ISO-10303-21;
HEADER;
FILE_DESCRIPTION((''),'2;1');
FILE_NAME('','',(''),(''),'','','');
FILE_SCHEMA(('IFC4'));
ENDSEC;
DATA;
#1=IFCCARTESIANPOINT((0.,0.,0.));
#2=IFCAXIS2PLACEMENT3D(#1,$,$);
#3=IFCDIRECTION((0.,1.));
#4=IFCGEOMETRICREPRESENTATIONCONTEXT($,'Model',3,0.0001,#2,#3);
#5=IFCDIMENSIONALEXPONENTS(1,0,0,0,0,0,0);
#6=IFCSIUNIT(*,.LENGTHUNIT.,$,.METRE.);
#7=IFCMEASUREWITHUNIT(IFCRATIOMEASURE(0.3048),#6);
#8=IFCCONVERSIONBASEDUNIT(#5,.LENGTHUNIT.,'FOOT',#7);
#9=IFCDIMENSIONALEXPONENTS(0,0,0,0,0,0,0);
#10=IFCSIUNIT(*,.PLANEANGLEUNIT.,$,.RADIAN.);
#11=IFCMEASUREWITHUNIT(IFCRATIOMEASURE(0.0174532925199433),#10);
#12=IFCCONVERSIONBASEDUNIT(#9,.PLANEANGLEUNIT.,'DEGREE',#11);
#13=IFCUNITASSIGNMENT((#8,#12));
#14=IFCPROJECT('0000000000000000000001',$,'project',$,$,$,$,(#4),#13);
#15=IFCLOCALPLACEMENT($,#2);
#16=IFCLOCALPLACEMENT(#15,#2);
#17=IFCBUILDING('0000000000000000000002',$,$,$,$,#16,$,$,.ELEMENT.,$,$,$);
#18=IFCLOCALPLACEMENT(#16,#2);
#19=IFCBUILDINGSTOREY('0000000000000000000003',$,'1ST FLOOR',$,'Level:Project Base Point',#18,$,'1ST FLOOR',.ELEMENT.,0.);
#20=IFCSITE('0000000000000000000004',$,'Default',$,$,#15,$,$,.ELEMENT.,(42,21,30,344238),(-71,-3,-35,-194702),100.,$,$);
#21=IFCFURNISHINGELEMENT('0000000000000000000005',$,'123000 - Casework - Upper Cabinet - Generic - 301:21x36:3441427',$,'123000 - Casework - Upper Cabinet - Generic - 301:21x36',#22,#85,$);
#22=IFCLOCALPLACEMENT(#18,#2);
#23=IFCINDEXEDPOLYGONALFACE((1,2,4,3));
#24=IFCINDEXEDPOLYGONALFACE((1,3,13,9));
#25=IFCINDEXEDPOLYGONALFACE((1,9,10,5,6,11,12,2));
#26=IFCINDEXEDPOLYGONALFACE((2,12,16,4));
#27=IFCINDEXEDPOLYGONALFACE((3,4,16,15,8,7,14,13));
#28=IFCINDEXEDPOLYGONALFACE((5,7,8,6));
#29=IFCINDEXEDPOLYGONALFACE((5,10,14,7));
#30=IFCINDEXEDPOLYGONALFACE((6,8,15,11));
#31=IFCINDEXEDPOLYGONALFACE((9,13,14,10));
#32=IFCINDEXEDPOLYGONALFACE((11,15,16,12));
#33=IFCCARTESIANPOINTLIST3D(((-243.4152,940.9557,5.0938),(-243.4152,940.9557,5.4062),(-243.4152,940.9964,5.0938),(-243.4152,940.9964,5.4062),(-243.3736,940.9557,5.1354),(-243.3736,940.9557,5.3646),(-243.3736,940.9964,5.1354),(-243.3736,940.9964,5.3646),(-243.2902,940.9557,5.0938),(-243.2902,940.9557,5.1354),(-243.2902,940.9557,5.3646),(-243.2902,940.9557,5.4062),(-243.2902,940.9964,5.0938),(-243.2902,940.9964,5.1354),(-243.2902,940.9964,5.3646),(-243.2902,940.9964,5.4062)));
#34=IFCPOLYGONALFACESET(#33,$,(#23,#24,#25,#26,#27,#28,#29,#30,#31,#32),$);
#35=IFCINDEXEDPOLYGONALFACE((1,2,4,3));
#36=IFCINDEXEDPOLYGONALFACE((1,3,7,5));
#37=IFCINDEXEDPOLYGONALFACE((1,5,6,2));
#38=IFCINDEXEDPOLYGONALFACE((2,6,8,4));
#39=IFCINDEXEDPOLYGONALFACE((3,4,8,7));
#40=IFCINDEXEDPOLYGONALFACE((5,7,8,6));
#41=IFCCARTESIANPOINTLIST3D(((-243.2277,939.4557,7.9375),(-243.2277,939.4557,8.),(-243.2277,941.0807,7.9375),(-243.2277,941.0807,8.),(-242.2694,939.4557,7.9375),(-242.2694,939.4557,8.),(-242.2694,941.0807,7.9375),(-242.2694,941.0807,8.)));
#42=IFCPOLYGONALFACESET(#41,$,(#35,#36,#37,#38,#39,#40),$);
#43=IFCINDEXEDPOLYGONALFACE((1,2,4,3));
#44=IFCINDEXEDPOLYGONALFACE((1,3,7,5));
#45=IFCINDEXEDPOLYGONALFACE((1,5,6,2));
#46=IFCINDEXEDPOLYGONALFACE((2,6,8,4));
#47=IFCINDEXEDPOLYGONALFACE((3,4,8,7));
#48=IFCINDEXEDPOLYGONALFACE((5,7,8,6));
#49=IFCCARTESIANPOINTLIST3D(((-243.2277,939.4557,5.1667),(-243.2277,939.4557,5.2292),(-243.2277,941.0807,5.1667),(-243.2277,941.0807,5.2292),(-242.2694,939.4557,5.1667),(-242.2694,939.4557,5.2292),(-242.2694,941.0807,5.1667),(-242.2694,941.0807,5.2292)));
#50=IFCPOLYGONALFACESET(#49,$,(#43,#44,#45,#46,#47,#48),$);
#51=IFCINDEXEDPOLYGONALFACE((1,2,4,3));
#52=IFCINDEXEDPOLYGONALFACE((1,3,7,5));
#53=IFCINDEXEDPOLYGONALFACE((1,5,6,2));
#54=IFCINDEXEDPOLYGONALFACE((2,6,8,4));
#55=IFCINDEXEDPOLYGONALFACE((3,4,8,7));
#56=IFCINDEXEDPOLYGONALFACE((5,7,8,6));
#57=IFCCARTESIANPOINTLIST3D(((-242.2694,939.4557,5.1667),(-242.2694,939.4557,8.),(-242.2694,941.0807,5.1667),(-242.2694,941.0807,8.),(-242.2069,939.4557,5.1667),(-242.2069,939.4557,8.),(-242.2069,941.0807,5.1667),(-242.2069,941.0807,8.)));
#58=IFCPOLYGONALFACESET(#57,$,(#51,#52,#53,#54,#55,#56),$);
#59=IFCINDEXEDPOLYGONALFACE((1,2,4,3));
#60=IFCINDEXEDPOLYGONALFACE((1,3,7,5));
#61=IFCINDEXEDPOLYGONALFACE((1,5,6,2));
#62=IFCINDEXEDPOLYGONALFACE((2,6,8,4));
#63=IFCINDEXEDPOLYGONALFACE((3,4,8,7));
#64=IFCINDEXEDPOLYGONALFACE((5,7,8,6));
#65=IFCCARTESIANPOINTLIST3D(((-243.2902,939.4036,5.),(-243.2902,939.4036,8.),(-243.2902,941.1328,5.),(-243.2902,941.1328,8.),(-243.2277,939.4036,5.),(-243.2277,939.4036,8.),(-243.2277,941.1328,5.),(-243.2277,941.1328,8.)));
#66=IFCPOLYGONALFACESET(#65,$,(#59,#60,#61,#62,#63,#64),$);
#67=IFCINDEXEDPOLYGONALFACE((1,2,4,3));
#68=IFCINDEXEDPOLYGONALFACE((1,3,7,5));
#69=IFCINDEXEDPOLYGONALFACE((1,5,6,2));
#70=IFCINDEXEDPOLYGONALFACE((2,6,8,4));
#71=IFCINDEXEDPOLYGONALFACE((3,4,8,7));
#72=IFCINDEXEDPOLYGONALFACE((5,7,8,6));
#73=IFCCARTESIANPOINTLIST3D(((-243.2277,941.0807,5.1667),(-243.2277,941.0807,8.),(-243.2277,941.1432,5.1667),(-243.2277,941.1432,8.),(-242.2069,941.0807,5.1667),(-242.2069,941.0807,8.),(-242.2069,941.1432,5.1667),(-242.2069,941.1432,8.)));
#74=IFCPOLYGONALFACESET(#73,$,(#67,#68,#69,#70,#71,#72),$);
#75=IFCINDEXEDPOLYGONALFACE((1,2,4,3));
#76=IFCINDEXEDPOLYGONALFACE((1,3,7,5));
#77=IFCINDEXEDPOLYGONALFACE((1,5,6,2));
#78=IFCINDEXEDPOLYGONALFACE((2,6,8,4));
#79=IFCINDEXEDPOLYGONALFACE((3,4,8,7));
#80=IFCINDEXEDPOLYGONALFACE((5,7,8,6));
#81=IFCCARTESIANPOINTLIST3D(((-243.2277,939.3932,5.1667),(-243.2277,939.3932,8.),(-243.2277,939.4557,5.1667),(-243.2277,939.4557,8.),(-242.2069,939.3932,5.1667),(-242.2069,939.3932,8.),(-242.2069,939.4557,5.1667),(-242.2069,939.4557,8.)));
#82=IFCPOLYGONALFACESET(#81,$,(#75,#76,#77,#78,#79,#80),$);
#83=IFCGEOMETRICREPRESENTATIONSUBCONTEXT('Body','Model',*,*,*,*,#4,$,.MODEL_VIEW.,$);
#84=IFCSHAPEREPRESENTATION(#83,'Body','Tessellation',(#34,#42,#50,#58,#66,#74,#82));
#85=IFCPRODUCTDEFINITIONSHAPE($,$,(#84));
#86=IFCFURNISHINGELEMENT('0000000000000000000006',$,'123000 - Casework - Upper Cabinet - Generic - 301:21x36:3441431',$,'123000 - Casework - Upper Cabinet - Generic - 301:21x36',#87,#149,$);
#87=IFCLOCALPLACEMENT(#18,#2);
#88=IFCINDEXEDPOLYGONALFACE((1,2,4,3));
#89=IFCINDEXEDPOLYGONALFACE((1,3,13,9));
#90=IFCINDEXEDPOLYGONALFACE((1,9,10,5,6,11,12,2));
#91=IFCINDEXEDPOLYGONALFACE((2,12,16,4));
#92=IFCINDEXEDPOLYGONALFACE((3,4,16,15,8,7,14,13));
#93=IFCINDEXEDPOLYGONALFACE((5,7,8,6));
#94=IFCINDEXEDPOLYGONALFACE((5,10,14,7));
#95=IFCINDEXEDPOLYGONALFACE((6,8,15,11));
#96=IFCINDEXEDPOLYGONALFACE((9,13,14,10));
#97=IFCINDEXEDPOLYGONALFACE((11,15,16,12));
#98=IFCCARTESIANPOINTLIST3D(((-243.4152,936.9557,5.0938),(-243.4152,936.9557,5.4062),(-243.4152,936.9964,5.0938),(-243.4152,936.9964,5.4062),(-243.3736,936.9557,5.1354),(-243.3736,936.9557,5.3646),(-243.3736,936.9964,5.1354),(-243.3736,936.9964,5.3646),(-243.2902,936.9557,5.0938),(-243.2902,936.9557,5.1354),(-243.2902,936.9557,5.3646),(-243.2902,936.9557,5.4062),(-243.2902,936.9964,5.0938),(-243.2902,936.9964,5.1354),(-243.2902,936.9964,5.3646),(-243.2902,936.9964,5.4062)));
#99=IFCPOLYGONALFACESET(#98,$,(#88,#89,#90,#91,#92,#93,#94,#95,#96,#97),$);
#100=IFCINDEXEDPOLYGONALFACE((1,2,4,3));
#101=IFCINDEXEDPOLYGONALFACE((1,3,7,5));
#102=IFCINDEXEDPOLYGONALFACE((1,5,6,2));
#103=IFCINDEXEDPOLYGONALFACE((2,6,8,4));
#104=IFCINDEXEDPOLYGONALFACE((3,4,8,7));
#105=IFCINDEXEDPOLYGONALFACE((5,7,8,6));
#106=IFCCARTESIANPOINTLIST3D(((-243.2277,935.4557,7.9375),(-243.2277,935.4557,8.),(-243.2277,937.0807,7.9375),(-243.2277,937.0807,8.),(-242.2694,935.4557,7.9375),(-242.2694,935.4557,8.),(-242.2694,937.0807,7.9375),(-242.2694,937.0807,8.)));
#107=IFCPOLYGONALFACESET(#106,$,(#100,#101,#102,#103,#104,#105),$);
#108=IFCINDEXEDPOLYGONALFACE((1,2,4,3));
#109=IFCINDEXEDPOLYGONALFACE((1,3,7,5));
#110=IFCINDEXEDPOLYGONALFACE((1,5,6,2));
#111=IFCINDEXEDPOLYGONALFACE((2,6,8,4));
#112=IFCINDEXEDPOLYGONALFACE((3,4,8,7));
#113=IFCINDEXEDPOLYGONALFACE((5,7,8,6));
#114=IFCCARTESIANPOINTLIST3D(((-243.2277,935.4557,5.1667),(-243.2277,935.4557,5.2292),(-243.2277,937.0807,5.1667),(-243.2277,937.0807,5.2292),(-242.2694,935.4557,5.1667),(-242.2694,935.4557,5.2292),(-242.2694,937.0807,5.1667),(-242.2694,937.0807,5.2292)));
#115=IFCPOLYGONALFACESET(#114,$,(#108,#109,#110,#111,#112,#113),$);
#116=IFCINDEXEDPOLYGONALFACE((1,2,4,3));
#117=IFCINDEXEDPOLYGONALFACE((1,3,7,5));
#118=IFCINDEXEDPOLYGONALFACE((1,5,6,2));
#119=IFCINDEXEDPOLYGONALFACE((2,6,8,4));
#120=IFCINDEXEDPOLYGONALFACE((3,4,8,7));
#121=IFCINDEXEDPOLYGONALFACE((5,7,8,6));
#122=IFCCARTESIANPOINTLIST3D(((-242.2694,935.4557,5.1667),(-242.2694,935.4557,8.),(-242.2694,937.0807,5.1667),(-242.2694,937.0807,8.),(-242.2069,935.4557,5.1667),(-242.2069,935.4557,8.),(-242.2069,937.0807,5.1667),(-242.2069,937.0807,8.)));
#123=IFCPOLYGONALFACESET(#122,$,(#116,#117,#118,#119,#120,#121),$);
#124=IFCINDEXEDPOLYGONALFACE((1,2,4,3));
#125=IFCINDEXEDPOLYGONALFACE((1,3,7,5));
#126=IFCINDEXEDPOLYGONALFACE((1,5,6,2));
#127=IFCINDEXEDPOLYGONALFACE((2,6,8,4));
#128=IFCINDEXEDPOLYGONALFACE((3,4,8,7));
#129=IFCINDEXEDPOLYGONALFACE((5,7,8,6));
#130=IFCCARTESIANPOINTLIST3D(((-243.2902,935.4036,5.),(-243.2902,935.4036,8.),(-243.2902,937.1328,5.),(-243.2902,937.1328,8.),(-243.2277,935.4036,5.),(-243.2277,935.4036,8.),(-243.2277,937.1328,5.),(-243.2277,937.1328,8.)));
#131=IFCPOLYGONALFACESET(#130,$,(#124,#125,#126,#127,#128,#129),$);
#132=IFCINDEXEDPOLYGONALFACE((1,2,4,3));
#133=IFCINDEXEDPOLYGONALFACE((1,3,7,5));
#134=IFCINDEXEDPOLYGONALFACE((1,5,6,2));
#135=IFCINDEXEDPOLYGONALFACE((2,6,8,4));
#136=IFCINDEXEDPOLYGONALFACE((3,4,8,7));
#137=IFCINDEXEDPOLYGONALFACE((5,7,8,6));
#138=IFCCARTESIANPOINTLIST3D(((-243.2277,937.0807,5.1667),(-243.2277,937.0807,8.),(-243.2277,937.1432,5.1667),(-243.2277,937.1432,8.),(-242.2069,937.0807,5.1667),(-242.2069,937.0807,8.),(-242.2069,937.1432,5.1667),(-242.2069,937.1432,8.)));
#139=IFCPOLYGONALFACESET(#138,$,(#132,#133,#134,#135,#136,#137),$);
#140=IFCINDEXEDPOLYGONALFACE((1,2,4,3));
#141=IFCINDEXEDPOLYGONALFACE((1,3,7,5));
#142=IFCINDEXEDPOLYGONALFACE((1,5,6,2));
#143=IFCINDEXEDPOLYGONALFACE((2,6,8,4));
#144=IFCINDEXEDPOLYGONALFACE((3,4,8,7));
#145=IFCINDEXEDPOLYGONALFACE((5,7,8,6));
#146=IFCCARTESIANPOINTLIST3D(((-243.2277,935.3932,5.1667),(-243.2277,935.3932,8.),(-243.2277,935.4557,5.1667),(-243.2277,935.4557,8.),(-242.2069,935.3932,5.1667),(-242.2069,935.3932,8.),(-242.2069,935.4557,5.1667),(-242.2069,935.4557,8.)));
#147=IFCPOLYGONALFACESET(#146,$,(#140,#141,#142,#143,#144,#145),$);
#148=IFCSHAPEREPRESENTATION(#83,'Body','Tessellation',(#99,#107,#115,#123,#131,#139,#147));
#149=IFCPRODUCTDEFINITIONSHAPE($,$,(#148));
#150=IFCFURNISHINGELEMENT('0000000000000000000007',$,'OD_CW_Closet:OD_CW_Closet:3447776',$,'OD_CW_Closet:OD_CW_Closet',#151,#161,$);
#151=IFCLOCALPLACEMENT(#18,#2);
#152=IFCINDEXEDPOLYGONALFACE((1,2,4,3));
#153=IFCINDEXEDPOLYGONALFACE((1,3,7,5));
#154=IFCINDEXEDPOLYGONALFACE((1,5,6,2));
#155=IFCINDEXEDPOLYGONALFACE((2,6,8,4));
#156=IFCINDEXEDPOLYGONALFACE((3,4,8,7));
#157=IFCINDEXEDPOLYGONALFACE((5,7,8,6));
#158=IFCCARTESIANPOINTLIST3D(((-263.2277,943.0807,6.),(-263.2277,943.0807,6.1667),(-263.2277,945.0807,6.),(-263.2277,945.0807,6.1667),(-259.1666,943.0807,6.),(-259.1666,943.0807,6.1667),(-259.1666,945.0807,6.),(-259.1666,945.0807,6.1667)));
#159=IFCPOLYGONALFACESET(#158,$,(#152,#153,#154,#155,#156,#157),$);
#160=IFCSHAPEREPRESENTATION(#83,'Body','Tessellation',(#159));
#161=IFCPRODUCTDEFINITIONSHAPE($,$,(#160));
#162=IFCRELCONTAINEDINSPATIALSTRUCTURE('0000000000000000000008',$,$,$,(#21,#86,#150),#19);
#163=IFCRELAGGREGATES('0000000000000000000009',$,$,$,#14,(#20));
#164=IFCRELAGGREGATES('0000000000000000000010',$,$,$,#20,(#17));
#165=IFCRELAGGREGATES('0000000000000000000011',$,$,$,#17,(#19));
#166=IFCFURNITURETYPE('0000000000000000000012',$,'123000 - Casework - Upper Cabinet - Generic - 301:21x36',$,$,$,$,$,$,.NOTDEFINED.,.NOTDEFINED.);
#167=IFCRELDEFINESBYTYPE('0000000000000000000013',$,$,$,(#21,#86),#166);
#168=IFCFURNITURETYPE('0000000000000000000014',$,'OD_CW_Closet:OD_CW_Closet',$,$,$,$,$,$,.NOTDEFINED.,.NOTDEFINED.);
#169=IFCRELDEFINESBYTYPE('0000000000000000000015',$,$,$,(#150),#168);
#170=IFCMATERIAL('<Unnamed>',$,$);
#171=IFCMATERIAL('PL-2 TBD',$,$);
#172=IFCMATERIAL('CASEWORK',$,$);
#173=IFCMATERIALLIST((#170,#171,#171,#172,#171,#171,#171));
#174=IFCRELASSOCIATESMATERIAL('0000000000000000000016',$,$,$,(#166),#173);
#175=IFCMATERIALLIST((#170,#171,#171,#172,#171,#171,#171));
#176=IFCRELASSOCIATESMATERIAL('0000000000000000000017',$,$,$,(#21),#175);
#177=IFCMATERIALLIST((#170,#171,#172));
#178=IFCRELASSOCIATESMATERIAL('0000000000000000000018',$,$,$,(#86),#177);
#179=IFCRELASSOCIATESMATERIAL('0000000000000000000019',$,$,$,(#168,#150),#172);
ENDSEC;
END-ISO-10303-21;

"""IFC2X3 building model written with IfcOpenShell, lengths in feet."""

from ifc_helpers import new_model, entity, si_unit, converted_unit, direction, frame, frame_2d, origin, origin_2d_with_axis, place, context, subcontext, project, spatial, polyline, rectangle, outline, extrude, source, transform, mapped, material, material_list, type_object, type_shapes, element, save


model = new_model("IFC2X3")

# Units and contexts
model_context = context("Model", 3, precision=0.0001, world=origin(), true_north=direction((0.0, 1.0)))
body_context = subcontext(model_context, "Body", "Model", "MODEL_VIEW")
ifc_project = project(units=[converted_unit("LENGTHUNIT", "FOOT", entity("IfcRatioMeasure", 0.3048), si_unit("LENGTHUNIT", "METRE"), dimensions=[1, 0, 0, 0, 0, 0, 0]), converted_unit("PLANEANGLEUNIT", "DEGREE", entity("IfcRatioMeasure", 0.0174532925199433), si_unit("PLANEANGLEUNIT", "RADIAN"), dimensions=[0, 0, 0, 0, 0, 0, 0])], contexts=[model_context])

# Site, building, storey
site_placement = place(None, origin())
site = spatial("IfcSite", under=ifc_project, at=site_placement, Name="Default", CompositionType="ELEMENT", RefLatitude=(42, 21, 30, 344238), RefLongitude=(-71, -3, -35, -194702), RefElevation=100.0)
building_placement = place(site_placement, origin())
building = spatial("IfcBuilding", under=site, at=building_placement, CompositionType="ELEMENT")
storey_placement = place(building_placement, origin())
storey = spatial("IfcBuildingStorey", under=building, at=storey_placement, Name="1ST FLOOR", ObjectType="Level:Project Base Point", LongName="1ST FLOOR", CompositionType="ELEMENT", Elevation=0.0)

# Furnishing elements
ifc_material_1 = material(Name="CASEWORK")
ifc_material_2 = material(Name="<Unnamed>")
ifc_material_3 = material(Name="PL-2 TBD")
ifc_material_list_1 = material_list([ifc_material_2, ifc_material_3, ifc_material_3, ifc_material_1, ifc_material_3, ifc_material_3, ifc_material_3])
ifc_material_list_2 = material_list([ifc_material_2, ifc_material_3, ifc_material_3, ifc_material_1, ifc_material_3, ifc_material_3, ifc_material_3])
furniture_type_1 = type_object("IfcFurnitureType", Name="123000 - Casework - Upper Cabinet - Generic - 301:21x36", material=ifc_material_list_2)
shared_shape_1 = source(origin(), body_context, "Body", "SweptSolid", [
    extrude(outline(polyline([(0.1146, -0.0521), (0.1562, -0.0521), (0.1562, 0.0729), (-0.1562, 0.0729), (-0.1562, -0.0521), (-0.1146, -0.0521), (-0.1146, 0.0313), (0.1146, 0.0313), (0.1146, -0.0521)])), frame((0.1468, 0.0729, 0.25), z_axis=(1.0, 0.0, 0.0), x_axis=(0.0, 0.0, 1.0)), (0.0, 0.0, 1.0), 0.0407),
    extrude(rectangle(XDim=1.625, YDim=0.9583, at=frame_2d((0.0, 0.0), x_axis=(1.0, 0.0))), frame((0.875, 0.6666, 2.9375), z_axis=(0.0, 0.0, 1.0), x_axis=(-1.0, 0.0, 0.0)), (0.0, 0.0, 1.0), 0.0625),
    extrude(rectangle(XDim=1.625, YDim=0.9583, at=frame_2d((0.0, 0.0), x_axis=(1.0, 0.0))), frame((0.875, 0.6666, 0.1667), z_axis=(0.0, 0.0, 1.0), x_axis=(-1.0, 0.0, 0.0)), (0.0, 0.0, 1.0), 0.0625),
    extrude(rectangle(XDim=0.0625, YDim=1.625, at=origin_2d_with_axis()), frame((0.875, 1.177, 0.1667), z_axis=(0.0, 0.0, 1.0), x_axis=(0.0, 1.0, 0.0)), (0.0, 0.0, 1.0), 2.8333),
    extrude(rectangle(XDim=0.0625, YDim=1.7292, at=frame_2d((0.0, 0.0), x_axis=(1.0, 0.0))), frame((0.875, 0.1562, 0.0), z_axis=(0.0, 0.0, 1.0), x_axis=(0.0, -1.0, 0.0)), (0.0, 0.0, 1.0), 3.0),
    extrude(rectangle(XDim=0.0625, YDim=1.0208, at=origin_2d_with_axis()), frame((0.0312, 0.6979, 0.1667), z_axis=(0.0, 0.0, 1.0), x_axis=(-1.0, 0.0, 0.0)), (0.0, 0.0, 1.0), 2.8333),
    extrude(rectangle(XDim=0.0625, YDim=1.0208, at=origin_2d_with_axis()), frame((1.7188, 0.6979, 0.1667), z_axis=(0.0, 0.0, 1.0), x_axis=(-1.0, 0.0, 0.0)), (0.0, 0.0, 1.0), 2.8333),
])
type_shapes(furniture_type_1, [shared_shape_1])
furnishing_1_placement = place(storey_placement, frame((-243.4152, 941.1432, 5.0), z_axis=(0.0, 0.0, 1.0), x_axis=(0.0, -1.0, 0.0)))
element("IfcFurnishingElement", 1, at=furnishing_1_placement, inside=storey, type_object=furniture_type_1, material=ifc_material_list_1, Name="123000 - Casework - Upper Cabinet - Generic - 301:21x36:3441427", ObjectType="123000 - Casework - Upper Cabinet - Generic - 301:21x36", context=body_context, shape_type="MappedRepresentation", body=[
    mapped(shared_shape_1, transform((0.0, 0.0, 0.0), scale=1.0)),
])
ifc_material_list_3 = material_list([ifc_material_2, ifc_material_3, ifc_material_1])
furnishing_2_placement = place(storey_placement, frame((-243.4152, 937.1432, 5.0), z_axis=(0.0, 0.0, 1.0), x_axis=(0.0, -1.0, 0.0)))
element("IfcFurnishingElement", 2, at=furnishing_2_placement, inside=storey, type_object=furniture_type_1, material=ifc_material_list_3, Name="123000 - Casework - Upper Cabinet - Generic - 301:21x36:3441431", ObjectType="123000 - Casework - Upper Cabinet - Generic - 301:21x36", context=body_context, shape_type="MappedRepresentation", body=[
    mapped(shared_shape_1, transform((0.0, 0.0, 0.0), scale=1.0)),
])
furniture_type_2 = type_object("IfcFurnitureType", Name="OD_CW_Closet:OD_CW_Closet", material=ifc_material_1)
shared_shape_2 = source(origin(), body_context, "Body", "SweptSolid", [
    extrude(rectangle(XDim=4.0612, YDim=2.0, at=origin_2d_with_axis()), frame((2.0306, 1.0, 0.0)), (0.0, 0.0, 1.0), 0.1667),
])
type_shapes(furniture_type_2, [shared_shape_2])
furnishing_3_placement = place(storey_placement, frame((-263.2277, 943.0807, 6.0)))
element("IfcFurnishingElement", 3, at=furnishing_3_placement, inside=storey, type_object=furniture_type_2, material=ifc_material_1, Name="OD_CW_Closet:OD_CW_Closet:3447776", ObjectType="OD_CW_Closet:OD_CW_Closet", context=body_context, shape_type="MappedRepresentation", body=[
    mapped(shared_shape_2, transform((0.0, 0.0, 0.0), scale=1.0)),
])

save(model, "model.ifc")
